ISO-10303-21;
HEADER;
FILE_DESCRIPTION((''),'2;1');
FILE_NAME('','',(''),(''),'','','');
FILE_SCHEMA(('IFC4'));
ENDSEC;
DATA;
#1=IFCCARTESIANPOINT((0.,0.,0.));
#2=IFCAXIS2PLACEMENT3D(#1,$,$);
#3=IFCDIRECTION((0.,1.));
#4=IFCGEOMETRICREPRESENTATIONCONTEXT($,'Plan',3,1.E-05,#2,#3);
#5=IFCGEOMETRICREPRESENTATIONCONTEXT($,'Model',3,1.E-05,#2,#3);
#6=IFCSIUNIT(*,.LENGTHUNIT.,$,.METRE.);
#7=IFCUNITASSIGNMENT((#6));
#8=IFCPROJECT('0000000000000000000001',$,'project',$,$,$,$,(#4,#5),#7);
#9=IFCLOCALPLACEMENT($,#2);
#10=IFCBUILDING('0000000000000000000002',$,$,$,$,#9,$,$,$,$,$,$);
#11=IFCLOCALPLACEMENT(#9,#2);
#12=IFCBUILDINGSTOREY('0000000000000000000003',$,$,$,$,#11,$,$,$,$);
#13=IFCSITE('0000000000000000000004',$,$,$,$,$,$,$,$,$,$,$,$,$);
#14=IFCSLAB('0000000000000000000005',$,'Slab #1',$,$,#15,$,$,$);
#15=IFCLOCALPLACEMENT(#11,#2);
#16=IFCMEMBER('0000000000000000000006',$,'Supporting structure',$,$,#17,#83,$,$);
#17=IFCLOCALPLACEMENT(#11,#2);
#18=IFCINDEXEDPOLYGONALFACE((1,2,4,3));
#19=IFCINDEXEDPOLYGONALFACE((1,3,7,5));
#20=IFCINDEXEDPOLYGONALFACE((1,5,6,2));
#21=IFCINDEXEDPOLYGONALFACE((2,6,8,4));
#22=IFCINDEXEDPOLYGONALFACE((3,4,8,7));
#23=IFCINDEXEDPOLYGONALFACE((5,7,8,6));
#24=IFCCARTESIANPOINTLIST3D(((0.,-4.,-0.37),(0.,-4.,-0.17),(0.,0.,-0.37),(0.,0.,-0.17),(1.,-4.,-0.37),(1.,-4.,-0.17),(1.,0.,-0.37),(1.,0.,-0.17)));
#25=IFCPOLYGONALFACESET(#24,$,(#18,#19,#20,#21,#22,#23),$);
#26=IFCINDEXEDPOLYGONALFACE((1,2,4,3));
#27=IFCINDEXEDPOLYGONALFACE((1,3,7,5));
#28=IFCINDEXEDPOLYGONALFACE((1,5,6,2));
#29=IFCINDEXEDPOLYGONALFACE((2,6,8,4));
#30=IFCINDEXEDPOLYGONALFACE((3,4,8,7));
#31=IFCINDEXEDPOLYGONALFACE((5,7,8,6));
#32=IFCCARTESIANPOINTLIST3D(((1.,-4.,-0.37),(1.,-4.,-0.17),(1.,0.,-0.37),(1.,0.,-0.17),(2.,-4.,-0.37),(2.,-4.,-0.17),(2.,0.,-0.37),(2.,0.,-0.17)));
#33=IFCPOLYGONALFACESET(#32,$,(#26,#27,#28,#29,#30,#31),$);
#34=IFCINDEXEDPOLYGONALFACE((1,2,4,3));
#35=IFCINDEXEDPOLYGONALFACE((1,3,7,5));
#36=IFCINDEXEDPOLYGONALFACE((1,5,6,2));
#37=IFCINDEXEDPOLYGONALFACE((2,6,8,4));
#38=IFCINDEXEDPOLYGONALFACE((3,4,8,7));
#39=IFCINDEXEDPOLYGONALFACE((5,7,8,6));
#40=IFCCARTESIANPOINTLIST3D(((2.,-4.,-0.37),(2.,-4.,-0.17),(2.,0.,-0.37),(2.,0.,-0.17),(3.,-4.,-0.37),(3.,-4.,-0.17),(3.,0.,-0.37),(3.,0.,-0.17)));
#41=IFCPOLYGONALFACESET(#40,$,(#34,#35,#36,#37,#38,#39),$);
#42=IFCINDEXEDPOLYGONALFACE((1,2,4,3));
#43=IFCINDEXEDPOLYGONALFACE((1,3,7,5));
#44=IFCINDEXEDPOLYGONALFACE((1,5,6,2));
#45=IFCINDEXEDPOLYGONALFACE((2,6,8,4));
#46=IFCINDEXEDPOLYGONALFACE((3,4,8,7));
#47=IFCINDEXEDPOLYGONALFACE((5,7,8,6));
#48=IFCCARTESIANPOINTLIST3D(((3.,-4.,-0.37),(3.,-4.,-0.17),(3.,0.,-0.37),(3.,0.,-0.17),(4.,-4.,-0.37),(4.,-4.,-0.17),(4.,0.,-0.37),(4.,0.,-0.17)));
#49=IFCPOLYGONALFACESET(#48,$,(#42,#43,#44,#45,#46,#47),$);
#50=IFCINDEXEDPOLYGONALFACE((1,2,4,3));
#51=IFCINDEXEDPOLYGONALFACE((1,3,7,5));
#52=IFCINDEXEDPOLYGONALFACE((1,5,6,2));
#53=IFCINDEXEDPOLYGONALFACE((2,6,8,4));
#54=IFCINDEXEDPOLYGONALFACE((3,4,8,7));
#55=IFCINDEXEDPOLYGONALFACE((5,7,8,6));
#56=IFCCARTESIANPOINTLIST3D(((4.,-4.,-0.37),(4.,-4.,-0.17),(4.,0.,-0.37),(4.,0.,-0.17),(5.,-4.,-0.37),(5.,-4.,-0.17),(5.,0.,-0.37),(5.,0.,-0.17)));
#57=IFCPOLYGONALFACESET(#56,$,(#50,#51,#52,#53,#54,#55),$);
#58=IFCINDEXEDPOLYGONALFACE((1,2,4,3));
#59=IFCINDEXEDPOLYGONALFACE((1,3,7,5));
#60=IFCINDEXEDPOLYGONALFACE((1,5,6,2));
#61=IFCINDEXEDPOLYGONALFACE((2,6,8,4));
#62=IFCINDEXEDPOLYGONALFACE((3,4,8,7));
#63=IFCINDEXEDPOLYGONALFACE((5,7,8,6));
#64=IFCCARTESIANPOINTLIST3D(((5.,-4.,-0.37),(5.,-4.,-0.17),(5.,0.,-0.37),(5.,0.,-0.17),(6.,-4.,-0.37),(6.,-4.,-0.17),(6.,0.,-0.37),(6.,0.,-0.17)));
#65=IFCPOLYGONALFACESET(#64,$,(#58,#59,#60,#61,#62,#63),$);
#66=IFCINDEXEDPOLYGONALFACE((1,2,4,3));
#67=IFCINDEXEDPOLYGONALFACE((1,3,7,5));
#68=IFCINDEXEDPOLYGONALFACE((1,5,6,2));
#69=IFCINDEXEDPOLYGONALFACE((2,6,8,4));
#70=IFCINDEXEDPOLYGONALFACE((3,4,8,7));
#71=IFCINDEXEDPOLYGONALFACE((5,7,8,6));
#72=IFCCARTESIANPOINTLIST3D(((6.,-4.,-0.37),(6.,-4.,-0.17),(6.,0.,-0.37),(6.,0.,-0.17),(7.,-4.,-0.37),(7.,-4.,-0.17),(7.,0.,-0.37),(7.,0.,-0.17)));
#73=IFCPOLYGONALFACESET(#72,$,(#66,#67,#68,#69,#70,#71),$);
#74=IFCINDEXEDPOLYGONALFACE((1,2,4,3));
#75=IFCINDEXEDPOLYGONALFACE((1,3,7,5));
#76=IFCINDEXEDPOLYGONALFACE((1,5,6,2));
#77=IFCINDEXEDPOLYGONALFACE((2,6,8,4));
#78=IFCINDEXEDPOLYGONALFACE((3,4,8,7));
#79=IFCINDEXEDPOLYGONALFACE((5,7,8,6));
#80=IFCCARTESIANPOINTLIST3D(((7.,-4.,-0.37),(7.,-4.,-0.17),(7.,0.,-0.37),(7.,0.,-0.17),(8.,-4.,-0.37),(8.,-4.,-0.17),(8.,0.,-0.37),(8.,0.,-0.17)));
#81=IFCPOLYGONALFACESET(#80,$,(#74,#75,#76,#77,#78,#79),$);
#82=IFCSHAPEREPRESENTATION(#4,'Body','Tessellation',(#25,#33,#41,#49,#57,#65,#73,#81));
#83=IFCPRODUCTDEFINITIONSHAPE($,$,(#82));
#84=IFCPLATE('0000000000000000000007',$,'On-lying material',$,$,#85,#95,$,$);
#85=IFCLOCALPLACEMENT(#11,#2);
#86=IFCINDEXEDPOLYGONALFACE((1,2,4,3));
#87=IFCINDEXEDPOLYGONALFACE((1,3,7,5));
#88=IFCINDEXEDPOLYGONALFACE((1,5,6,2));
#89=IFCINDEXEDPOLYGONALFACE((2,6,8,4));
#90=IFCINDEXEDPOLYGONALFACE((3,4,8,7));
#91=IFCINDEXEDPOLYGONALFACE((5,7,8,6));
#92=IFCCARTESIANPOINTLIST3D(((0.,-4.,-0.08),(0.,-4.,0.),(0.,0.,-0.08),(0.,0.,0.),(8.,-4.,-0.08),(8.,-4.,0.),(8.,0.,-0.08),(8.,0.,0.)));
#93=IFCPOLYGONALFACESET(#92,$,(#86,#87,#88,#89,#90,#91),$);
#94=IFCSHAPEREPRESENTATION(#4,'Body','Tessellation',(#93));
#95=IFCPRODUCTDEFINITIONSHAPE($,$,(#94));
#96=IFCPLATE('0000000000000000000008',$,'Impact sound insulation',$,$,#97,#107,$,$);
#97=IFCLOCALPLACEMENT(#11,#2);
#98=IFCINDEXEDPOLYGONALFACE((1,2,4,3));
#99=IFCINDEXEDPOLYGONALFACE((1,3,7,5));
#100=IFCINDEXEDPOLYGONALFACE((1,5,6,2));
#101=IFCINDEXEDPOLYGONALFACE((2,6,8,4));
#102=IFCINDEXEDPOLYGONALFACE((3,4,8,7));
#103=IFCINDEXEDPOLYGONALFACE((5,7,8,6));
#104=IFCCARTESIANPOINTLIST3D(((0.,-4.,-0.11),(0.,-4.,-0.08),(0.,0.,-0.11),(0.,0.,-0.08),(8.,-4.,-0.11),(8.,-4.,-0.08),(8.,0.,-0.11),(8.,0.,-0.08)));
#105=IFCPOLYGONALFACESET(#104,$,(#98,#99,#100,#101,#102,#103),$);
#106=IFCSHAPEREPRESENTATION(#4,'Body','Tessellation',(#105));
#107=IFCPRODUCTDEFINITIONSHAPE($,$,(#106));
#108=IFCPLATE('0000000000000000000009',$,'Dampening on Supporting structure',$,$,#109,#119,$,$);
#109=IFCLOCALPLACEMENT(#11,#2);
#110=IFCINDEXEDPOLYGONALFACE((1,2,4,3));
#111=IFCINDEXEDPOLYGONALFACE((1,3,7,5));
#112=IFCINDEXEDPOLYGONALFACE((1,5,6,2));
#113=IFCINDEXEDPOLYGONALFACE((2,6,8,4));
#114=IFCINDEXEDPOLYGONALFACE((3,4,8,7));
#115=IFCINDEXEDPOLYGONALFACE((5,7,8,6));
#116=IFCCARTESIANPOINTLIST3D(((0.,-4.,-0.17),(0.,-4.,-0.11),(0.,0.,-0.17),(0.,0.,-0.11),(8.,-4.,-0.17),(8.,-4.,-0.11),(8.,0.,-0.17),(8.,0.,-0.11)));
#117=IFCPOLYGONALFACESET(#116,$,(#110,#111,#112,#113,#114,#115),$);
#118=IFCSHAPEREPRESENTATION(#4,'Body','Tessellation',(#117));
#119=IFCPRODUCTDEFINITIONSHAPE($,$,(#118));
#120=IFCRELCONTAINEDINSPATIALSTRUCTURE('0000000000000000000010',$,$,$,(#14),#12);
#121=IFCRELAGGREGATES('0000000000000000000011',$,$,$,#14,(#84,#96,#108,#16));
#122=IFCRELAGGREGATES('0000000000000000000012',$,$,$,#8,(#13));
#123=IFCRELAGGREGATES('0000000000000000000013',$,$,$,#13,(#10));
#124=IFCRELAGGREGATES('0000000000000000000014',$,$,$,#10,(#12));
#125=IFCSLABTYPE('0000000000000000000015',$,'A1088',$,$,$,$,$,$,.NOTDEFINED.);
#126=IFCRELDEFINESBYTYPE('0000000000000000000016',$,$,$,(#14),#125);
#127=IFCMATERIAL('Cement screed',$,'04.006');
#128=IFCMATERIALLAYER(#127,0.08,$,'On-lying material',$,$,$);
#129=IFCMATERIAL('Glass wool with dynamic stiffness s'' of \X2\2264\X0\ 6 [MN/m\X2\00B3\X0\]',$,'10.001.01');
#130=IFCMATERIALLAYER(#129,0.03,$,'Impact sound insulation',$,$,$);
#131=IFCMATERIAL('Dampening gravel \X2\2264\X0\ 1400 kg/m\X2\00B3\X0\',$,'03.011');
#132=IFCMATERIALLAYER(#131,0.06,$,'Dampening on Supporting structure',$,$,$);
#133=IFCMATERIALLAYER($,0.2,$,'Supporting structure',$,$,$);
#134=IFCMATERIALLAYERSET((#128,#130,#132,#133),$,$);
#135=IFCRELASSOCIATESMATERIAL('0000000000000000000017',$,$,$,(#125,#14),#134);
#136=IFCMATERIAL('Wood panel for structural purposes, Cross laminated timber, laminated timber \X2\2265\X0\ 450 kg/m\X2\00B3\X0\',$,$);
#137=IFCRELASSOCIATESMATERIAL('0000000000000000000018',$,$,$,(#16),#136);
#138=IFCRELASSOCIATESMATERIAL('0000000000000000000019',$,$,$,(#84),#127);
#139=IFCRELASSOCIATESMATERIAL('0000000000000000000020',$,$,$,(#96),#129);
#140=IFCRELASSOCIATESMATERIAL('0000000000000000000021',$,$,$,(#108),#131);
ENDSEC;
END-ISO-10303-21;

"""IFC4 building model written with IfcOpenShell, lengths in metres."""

from ifc_helpers import new_model, si_unit, direction, frame, frame_2d, origin, origin_with_axes, place, context, project, spatial, rectangle, extrude, material, layer, layer_set, type_object, element, aggregate, save


model = new_model("IFC4")

# Units and contexts
plan_context = context("Plan", 3, precision=1e-05, world=origin(), true_north=direction((0.0, 1.0)))
model_context = context("Model", 3, precision=1e-05, world=origin(), true_north=direction((0.0, 1.0)))
ifc_project = project(units=[si_unit("LENGTHUNIT", "METRE")], contexts=[plan_context, model_context])

# Site, building, storey
site = spatial("IfcSite", under=ifc_project)
building_placement = place(None, origin())
building = spatial("IfcBuilding", under=site, at=building_placement)
storey_placement = place(building_placement, origin())
storey = spatial("IfcBuildingStorey", under=building, at=storey_placement)

# Slab, member, plates
ifc_material_1 = material(Name="Cement screed", Category="04.006")
ifc_layer_1 = layer(ifc_material_1, 0.08, Name="On-lying material")
ifc_material_2 = material(Name="Glass wool with dynamic stiffness s' of ≤ 6 [MN/m³]", Category="10.001.01")
ifc_layer_2 = layer(ifc_material_2, 0.03, Name="Impact sound insulation")
ifc_material_3 = material(Name="Dampening gravel ≤ 1400 kg/m³", Category="03.011")
ifc_layer_3 = layer(ifc_material_3, 0.06, Name="Dampening on Supporting structure")
ifc_layer_4 = layer(None, 0.2, Name="Supporting structure")
ifc_layer_set = layer_set([ifc_layer_1, ifc_layer_2, ifc_layer_3, ifc_layer_4])
slab_type = type_object("IfcSlabType", Name="A1088", PredefinedType="NOTDEFINED", material=ifc_layer_set)
slab_placement = place(None, frame((0.0, 0.0, 0.0), z_axis=(0.0, 0.0, -1.0), x_axis=(1.0, 0.0, 0.0)))
slab = element("IfcSlab", 1, at=slab_placement, inside=storey, type_object=slab_type, material=ifc_layer_set, Name="Slab #1")
ifc_material_4 = material(Name="Wood panel for structural purposes, Cross laminated timber, laminated timber ≥ 450 kg/m³")
member_placement = place(slab_placement, origin())
member = element("IfcMember", 2, at=member_placement, material=ifc_material_4, Name="Supporting structure", context=plan_context, shape_type="SweptSolid", body=[
    extrude(rectangle(XDim=1.0, YDim=0.2, at=frame_2d((0.5, 0.1), x_axis=(1.0, 0.0))), frame((0.0, 4.0, 0.17), z_axis=(0.0, -1.0, 0.0), x_axis=(1.0, 0.0, 0.0)), (0.0, 0.0, 1.0), 4.0),
    extrude(rectangle(XDim=1.0, YDim=0.2, at=frame_2d((0.5, 0.1), x_axis=(1.0, 0.0))), frame((1.0, 4.0, 0.17), z_axis=(0.0, -1.0, 0.0), x_axis=(1.0, 0.0, 0.0)), (0.0, 0.0, 1.0), 4.0),
    extrude(rectangle(XDim=1.0, YDim=0.2, at=frame_2d((0.5, 0.1), x_axis=(1.0, 0.0))), frame((2.0, 4.0, 0.17), z_axis=(0.0, -1.0, 0.0), x_axis=(1.0, 0.0, 0.0)), (0.0, 0.0, 1.0), 4.0),
    extrude(rectangle(XDim=1.0, YDim=0.2, at=frame_2d((0.5, 0.1), x_axis=(1.0, 0.0))), frame((3.0, 4.0, 0.17), z_axis=(0.0, -1.0, 0.0), x_axis=(1.0, 0.0, 0.0)), (0.0, 0.0, 1.0), 4.0),
    extrude(rectangle(XDim=1.0, YDim=0.2, at=frame_2d((0.5, 0.1), x_axis=(1.0, 0.0))), frame((4.0, 4.0, 0.17), z_axis=(0.0, -1.0, 0.0), x_axis=(1.0, 0.0, 0.0)), (0.0, 0.0, 1.0), 4.0),
    extrude(rectangle(XDim=1.0, YDim=0.2, at=frame_2d((0.5, 0.1), x_axis=(1.0, 0.0))), frame((5.0, 4.0, 0.17), z_axis=(0.0, -1.0, 0.0), x_axis=(1.0, 0.0, 0.0)), (0.0, 0.0, 1.0), 4.0),
    extrude(rectangle(XDim=1.0, YDim=0.2, at=frame_2d((0.5, 0.1), x_axis=(1.0, 0.0))), frame((6.0, 4.0, 0.17), z_axis=(0.0, -1.0, 0.0), x_axis=(1.0, 0.0, 0.0)), (0.0, 0.0, 1.0), 4.0),
    extrude(rectangle(XDim=1.0, YDim=0.2, at=frame_2d((0.5, 0.1), x_axis=(1.0, 0.0))), frame((7.0, 4.0, 0.17), z_axis=(0.0, -1.0, 0.0), x_axis=(1.0, 0.0, 0.0)), (0.0, 0.0, 1.0), 4.0),
])
plate_1_placement = place(slab_placement, origin())
plate_1 = element("IfcPlate", 3, at=plate_1_placement, material=ifc_material_1, Name="On-lying material", context=plan_context, shape_type="SweptSolid", body=[
    extrude(rectangle(XDim=8.0, YDim=4.0, at=frame_2d((4.0, 2.0), x_axis=(1.0, 0.0))), origin_with_axes(), (0.0, 0.0, 1.0), 0.08),
])
plate_2_placement = place(slab_placement, origin())
plate_2 = element("IfcPlate", 4, at=plate_2_placement, material=ifc_material_2, Name="Impact sound insulation", context=plan_context, shape_type="SweptSolid", body=[
    extrude(rectangle(XDim=8.0, YDim=4.0, at=frame_2d((4.0, 2.0), x_axis=(1.0, 0.0))), frame((0.0, 0.0, 0.08), z_axis=(0.0, 0.0, 1.0), x_axis=(1.0, 0.0, 0.0)), (0.0, 0.0, 1.0), 0.03),
])
plate_3_placement = place(slab_placement, origin())
plate_3 = element("IfcPlate", 5, at=plate_3_placement, material=ifc_material_3, Name="Dampening on Supporting structure", context=plan_context, shape_type="SweptSolid", body=[
    extrude(rectangle(XDim=8.0, YDim=4.0, at=frame_2d((4.0, 2.0), x_axis=(1.0, 0.0))), frame((0.0, 0.0, 0.11), z_axis=(0.0, 0.0, 1.0), x_axis=(1.0, 0.0, 0.0)), (0.0, 0.0, 1.0), 0.06),
])
aggregate(slab, [plate_1, plate_2, plate_3, member])

save(model, "model.ifc")
